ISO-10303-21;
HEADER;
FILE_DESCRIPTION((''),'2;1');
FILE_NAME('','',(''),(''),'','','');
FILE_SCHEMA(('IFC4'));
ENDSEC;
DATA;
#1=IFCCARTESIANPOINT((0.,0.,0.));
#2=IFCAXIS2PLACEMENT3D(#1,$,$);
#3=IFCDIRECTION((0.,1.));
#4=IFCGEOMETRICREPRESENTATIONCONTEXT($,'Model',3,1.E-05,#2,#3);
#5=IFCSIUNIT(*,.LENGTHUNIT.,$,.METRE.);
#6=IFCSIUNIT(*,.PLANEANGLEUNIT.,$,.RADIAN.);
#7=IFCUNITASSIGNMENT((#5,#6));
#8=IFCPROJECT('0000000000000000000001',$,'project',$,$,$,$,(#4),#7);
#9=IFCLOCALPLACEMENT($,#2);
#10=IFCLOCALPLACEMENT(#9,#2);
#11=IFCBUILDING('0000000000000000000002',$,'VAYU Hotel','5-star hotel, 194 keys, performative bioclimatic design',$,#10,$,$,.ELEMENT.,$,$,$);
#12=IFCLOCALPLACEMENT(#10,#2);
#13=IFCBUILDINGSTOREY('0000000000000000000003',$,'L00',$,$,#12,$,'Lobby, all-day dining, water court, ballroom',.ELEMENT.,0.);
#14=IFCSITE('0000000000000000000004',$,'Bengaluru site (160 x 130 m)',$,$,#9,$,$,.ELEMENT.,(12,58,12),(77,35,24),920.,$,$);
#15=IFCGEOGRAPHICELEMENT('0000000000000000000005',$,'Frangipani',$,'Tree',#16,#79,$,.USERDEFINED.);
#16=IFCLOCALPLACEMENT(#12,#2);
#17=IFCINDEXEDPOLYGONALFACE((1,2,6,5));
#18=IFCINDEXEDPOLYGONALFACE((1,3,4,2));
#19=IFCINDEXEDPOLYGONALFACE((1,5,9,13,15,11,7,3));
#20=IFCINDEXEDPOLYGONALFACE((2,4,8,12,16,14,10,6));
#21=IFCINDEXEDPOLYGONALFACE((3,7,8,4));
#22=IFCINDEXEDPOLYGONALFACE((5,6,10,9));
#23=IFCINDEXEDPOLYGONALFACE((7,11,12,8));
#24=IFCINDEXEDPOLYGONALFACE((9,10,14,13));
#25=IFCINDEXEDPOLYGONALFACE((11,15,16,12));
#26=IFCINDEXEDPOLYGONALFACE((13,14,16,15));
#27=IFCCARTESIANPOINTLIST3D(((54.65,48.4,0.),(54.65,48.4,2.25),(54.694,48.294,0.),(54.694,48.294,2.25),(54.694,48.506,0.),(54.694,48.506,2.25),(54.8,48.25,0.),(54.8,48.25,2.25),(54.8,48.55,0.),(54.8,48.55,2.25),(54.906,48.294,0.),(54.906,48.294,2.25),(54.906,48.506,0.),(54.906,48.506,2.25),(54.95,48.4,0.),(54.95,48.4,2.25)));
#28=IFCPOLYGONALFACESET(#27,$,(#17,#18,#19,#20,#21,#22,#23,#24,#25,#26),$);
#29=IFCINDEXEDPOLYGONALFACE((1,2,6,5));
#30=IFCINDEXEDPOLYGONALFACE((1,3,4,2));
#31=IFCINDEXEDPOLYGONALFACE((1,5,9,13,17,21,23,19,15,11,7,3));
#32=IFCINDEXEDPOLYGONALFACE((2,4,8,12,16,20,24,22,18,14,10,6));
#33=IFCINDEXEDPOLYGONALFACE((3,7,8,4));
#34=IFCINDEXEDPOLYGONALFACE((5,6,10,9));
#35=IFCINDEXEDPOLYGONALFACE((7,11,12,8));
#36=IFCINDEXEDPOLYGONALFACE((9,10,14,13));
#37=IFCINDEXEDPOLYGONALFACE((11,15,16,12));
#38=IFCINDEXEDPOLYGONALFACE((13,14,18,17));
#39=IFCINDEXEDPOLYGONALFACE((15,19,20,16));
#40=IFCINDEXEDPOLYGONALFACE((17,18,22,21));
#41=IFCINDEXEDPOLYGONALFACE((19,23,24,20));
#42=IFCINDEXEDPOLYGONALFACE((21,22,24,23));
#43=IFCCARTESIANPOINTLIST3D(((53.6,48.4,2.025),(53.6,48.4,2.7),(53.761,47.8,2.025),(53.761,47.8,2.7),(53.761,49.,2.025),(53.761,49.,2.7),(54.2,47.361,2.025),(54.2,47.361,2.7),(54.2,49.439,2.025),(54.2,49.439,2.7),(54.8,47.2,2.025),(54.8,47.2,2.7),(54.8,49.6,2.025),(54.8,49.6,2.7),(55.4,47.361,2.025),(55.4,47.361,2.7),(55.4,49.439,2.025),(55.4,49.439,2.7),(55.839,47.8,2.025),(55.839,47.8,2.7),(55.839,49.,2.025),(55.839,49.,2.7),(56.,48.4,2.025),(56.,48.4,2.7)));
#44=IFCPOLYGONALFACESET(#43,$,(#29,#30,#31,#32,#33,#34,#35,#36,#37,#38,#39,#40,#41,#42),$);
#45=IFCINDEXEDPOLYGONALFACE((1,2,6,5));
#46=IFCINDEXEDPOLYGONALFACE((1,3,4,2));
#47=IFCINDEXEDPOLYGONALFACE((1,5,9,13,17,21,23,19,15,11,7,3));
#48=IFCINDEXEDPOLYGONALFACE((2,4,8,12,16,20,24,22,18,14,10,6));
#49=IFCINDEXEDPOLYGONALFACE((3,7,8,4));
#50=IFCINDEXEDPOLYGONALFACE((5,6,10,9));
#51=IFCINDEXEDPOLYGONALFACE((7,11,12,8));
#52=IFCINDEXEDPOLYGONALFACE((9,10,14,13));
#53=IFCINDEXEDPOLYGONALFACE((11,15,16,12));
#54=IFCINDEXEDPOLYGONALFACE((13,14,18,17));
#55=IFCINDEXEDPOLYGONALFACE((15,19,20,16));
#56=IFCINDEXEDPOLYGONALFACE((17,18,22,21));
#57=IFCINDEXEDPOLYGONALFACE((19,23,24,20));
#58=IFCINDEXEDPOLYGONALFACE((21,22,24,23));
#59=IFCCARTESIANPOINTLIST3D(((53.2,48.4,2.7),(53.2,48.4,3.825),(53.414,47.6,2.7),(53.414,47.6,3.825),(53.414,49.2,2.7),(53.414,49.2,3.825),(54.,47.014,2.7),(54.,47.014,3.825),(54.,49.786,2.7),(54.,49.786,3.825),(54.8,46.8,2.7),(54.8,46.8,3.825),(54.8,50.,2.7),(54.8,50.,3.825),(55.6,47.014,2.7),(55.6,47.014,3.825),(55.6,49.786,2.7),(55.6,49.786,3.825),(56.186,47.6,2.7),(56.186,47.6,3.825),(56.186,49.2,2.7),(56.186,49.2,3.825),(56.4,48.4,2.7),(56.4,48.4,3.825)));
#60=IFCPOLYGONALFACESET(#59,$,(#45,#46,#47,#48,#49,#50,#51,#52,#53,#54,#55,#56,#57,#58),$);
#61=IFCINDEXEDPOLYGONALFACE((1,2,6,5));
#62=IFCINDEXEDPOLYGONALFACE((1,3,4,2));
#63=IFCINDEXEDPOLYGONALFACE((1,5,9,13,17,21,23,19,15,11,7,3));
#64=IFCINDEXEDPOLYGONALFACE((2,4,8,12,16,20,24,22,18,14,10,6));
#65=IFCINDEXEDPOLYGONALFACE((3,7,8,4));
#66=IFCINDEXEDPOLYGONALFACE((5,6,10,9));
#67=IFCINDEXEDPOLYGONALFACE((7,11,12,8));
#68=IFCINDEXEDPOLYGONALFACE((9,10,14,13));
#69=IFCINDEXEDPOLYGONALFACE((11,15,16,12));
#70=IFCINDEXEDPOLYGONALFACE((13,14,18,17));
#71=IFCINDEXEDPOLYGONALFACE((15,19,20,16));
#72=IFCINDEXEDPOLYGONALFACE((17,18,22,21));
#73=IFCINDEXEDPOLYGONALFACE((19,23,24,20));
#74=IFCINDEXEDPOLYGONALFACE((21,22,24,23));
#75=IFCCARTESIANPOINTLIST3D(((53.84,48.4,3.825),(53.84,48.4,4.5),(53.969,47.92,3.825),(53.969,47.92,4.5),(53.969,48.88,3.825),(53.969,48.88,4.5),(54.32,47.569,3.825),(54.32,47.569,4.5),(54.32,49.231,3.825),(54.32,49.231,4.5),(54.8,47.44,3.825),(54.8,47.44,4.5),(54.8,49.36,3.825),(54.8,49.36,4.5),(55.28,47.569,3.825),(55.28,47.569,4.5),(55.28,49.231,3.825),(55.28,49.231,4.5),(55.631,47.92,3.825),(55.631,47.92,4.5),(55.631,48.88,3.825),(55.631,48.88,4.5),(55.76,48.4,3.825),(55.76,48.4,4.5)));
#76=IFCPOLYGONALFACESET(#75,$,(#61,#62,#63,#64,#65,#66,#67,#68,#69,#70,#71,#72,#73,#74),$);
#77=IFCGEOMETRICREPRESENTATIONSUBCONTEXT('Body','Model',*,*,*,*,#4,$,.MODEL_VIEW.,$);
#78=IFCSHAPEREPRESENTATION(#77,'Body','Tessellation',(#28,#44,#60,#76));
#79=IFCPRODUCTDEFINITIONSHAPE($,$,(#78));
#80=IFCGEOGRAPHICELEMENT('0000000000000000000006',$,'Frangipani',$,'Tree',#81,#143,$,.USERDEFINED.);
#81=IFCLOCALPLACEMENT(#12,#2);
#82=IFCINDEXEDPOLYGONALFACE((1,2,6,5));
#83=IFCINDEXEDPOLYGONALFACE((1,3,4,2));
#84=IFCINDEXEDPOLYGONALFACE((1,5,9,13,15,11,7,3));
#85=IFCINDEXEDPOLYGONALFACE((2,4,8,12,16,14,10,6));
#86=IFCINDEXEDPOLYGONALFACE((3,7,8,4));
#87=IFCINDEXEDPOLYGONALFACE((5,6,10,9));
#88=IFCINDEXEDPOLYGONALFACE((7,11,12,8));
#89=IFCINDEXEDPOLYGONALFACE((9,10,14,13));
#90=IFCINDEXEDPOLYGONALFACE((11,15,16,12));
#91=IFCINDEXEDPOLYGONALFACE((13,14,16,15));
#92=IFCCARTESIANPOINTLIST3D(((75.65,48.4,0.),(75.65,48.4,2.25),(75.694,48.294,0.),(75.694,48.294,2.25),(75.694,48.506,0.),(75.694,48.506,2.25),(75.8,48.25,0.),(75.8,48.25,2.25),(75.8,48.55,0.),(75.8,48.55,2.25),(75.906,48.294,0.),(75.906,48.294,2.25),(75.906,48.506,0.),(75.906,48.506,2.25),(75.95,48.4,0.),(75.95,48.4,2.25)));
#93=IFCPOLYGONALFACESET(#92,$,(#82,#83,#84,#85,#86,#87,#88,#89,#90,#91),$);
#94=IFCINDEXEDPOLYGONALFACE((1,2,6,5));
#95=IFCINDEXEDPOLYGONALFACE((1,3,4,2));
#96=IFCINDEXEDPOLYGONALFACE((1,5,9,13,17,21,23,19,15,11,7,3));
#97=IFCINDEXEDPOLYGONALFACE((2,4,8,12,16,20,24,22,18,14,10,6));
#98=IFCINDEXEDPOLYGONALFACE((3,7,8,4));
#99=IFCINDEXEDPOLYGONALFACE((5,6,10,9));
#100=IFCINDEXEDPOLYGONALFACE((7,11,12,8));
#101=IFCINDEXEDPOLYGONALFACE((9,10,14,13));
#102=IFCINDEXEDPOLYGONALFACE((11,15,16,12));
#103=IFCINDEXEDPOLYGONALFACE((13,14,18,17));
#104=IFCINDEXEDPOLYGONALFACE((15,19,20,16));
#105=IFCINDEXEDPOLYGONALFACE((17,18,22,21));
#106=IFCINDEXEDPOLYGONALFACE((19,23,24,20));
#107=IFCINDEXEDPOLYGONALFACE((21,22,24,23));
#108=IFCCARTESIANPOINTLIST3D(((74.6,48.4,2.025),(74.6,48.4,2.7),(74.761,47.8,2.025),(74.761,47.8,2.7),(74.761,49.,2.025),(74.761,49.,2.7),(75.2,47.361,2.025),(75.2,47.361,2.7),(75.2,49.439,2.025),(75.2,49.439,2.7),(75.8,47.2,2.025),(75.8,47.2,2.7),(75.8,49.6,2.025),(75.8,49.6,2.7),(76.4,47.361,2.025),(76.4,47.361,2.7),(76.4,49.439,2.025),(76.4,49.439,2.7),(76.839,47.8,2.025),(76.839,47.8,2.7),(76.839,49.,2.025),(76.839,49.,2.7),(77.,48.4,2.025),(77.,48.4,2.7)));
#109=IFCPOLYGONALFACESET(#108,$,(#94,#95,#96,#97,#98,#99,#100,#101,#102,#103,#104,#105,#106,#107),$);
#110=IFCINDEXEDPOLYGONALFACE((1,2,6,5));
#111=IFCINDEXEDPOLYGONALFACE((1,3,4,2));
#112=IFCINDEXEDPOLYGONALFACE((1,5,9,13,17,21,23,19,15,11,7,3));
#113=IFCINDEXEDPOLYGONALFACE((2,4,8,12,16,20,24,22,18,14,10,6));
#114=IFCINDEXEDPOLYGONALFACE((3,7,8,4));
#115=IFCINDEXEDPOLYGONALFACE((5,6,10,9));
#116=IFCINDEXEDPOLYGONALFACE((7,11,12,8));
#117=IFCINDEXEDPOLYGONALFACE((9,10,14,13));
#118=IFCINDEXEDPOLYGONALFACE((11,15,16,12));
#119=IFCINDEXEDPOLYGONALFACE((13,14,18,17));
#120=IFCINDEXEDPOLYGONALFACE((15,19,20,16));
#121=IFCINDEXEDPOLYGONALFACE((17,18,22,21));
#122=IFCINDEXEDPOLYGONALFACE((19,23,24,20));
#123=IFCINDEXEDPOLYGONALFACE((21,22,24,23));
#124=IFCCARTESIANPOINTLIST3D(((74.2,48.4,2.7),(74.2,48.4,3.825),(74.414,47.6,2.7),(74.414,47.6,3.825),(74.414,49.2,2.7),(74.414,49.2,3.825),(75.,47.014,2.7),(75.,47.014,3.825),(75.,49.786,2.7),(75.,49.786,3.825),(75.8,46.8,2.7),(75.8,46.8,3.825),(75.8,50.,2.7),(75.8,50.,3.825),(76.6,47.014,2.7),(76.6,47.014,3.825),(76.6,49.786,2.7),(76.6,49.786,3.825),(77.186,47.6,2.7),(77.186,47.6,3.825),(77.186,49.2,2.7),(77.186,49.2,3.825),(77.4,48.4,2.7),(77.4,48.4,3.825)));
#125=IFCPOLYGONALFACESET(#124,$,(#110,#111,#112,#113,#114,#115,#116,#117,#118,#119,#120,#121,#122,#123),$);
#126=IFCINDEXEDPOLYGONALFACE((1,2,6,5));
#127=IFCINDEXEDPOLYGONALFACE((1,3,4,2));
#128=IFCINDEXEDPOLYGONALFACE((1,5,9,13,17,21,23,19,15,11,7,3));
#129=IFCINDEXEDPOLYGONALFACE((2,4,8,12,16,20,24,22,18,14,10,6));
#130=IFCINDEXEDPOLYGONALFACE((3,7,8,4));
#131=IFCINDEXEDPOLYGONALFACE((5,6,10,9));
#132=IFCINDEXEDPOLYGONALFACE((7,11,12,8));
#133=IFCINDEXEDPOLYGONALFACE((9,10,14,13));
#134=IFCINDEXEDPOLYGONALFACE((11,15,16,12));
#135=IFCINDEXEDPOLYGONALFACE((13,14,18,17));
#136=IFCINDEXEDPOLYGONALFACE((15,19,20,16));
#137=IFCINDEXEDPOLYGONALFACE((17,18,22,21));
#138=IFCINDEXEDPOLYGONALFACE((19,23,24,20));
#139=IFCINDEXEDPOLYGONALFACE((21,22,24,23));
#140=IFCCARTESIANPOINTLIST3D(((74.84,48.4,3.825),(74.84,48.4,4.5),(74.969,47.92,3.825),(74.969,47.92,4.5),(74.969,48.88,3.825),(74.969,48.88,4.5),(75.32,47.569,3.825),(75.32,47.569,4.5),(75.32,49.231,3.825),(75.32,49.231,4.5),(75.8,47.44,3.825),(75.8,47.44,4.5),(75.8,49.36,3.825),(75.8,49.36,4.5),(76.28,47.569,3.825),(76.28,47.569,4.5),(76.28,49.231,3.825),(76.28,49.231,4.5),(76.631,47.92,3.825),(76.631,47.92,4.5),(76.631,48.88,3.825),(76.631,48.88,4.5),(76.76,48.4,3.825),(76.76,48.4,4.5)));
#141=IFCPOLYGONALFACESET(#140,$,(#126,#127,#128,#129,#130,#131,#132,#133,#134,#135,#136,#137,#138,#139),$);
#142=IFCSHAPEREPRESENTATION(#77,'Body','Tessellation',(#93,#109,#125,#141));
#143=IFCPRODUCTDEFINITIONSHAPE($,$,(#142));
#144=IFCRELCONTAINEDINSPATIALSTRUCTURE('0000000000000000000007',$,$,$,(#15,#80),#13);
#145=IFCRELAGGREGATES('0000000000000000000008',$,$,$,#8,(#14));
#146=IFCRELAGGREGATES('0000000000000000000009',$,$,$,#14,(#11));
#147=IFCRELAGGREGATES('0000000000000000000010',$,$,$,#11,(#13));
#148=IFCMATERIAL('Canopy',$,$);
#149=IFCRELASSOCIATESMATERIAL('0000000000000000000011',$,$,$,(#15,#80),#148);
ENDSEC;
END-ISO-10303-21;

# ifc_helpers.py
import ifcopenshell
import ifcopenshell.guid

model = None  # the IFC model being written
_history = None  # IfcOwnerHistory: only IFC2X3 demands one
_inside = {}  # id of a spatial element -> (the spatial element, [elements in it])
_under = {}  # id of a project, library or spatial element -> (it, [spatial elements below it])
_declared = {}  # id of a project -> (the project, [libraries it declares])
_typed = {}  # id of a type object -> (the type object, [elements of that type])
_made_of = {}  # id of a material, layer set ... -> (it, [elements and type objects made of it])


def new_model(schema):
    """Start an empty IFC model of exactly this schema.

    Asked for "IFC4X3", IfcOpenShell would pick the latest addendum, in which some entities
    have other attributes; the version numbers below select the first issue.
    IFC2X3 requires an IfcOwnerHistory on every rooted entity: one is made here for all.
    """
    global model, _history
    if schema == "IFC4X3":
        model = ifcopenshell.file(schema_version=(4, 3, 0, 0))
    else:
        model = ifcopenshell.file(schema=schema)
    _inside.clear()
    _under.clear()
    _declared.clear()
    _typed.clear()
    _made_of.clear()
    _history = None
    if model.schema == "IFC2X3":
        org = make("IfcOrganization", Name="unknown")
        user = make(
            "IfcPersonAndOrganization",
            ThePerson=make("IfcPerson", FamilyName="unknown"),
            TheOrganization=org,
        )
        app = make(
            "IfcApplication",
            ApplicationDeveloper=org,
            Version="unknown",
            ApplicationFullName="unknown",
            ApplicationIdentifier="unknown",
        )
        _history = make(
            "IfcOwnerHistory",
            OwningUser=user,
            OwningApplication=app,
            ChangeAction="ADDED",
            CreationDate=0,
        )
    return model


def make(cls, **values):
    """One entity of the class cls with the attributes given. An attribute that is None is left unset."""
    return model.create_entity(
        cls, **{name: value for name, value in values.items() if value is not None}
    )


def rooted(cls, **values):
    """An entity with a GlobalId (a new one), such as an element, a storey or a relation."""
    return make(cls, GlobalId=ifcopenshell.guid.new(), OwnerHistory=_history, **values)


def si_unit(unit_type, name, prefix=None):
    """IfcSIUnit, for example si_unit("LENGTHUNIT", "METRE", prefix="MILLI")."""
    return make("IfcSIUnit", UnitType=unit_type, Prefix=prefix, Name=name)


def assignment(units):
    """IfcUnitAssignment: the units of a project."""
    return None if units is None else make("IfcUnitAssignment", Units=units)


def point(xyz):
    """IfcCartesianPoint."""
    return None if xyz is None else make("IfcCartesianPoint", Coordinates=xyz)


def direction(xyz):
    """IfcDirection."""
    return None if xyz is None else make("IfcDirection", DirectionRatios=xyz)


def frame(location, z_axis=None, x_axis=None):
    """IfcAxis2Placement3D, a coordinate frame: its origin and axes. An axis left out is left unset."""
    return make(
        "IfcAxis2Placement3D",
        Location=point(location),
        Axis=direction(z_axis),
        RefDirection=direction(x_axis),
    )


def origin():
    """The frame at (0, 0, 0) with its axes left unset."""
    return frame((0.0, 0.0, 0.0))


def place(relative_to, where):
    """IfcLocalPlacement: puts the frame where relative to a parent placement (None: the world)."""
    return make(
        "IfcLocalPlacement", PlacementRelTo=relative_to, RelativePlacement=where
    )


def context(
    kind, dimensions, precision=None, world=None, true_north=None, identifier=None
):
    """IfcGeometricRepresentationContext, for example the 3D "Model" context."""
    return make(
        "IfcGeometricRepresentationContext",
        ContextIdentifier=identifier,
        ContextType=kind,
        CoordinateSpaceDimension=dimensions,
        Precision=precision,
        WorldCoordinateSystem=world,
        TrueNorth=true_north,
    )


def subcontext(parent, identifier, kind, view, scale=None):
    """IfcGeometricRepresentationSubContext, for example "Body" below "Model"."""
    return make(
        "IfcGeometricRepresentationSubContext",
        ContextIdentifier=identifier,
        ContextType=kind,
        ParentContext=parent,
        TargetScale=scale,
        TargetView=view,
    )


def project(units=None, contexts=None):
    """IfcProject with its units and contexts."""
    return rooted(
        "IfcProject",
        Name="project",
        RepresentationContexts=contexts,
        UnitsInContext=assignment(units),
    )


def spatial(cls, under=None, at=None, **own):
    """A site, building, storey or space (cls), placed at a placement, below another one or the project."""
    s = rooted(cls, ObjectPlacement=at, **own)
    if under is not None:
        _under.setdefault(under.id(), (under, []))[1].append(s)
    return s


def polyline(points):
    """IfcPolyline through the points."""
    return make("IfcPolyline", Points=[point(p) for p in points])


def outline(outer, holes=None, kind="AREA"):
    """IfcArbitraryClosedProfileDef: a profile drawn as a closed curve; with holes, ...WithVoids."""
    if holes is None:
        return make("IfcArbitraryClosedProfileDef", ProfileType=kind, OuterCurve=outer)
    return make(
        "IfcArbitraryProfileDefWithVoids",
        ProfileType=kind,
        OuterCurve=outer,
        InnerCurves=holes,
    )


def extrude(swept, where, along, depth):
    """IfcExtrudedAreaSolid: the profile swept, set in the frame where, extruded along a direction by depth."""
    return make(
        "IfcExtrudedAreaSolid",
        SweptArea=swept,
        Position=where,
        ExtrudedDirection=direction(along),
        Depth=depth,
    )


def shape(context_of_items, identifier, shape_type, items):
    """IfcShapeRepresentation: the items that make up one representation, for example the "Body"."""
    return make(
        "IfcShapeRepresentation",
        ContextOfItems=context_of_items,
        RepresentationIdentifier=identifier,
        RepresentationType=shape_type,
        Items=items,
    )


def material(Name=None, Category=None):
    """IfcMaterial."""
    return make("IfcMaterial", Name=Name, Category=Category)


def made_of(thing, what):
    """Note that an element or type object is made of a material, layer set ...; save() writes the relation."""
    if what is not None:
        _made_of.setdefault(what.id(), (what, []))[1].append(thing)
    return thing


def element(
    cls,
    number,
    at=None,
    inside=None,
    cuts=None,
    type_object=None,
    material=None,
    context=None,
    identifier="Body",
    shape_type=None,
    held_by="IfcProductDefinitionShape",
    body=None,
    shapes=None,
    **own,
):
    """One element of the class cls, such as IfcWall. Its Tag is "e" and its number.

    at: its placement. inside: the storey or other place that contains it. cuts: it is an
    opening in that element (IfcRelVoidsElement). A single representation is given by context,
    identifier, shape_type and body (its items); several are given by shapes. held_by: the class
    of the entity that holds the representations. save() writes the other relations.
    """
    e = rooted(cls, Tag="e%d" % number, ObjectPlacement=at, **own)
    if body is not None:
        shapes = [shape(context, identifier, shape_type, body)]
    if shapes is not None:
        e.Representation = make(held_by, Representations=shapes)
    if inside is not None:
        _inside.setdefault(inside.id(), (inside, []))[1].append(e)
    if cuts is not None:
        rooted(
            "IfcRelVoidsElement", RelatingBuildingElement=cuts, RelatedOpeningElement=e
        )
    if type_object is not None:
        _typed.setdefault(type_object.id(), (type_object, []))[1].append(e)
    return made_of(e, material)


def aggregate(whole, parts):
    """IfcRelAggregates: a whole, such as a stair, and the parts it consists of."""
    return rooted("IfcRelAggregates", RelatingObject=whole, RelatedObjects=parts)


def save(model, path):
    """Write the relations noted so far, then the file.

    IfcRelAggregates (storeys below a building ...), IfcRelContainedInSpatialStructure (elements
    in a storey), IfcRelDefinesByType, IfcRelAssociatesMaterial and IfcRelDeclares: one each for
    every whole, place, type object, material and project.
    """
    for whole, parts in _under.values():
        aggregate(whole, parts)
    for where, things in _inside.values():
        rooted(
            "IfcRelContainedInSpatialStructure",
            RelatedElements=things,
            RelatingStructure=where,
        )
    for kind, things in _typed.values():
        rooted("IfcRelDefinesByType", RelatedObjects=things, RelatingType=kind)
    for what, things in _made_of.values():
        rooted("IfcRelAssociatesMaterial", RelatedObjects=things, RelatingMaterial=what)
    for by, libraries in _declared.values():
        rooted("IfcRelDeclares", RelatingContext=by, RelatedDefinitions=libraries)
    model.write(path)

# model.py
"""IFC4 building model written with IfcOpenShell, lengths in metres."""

from ifc_helpers import new_model, si_unit, direction, frame, origin, place, context, subcontext, project, spatial, polyline, outline, extrude, material, element, save


model = new_model("IFC4")

# Units and contexts
model_context = context("Model", 3, precision=1e-05, world=origin(), true_north=direction((0.0, 1.0)))
body_context = subcontext(model_context, "Body", "Model", "MODEL_VIEW")
ifc_project = project(units=[si_unit("LENGTHUNIT", "METRE"), si_unit("PLANEANGLEUNIT", "RADIAN")], contexts=[model_context])

# Site, building, storey
site_placement = place(None, origin())
site = spatial("IfcSite", under=ifc_project, at=site_placement, Name="Bengaluru site (160 x 130 m)", CompositionType="ELEMENT", RefLatitude=(12, 58, 12), RefLongitude=(77, 35, 24), RefElevation=920.0)
building_placement = place(site_placement, origin())
building = spatial("IfcBuilding", under=site, at=building_placement, Name="VAYU Hotel", Description="5-star hotel, 194 keys, performative bioclimatic design", CompositionType="ELEMENT")
storey_placement = place(building_placement, origin())
storey = spatial("IfcBuildingStorey", under=building, at=storey_placement, Name="L00", LongName="Lobby, all-day dining, water court, ballroom", CompositionType="ELEMENT", Elevation=0.0)

# Geographic elements
ifc_material_1 = material(Name="Canopy")
geographic_element_1_placement = place(storey_placement, origin())
element("IfcGeographicElement", 1, at=geographic_element_1_placement, inside=storey, material=ifc_material_1, Name="Frangipani", ObjectType="Tree", PredefinedType="USERDEFINED", context=body_context, shape_type="SweptSolid", body=[
    extrude(outline(polyline([(54.95, 48.4), (54.906, 48.506), (54.8, 48.55), (54.694, 48.506), (54.65, 48.4), (54.694, 48.294), (54.8, 48.25), (54.906, 48.294), (54.95, 48.4)])), origin(), (0.0, 0.0, 1.0), 2.25),
    extrude(outline(polyline([(56.0, 48.4), (55.839, 49.0), (55.4, 49.439), (54.8, 49.6), (54.2, 49.439), (53.761, 49.0), (53.6, 48.4), (53.761, 47.8), (54.2, 47.361), (54.8, 47.2), (55.4, 47.361), (55.839, 47.8), (56.0, 48.4)])), frame((0.0, 0.0, 2.025)), (0.0, 0.0, 1.0), 0.675),
    extrude(outline(polyline([(56.4, 48.4), (56.186, 49.2), (55.6, 49.786), (54.8, 50.0), (54.0, 49.786), (53.414, 49.2), (53.2, 48.4), (53.414, 47.6), (54.0, 47.014), (54.8, 46.8), (55.6, 47.014), (56.186, 47.6), (56.4, 48.4)])), frame((0.0, 0.0, 2.7)), (0.0, 0.0, 1.0), 1.125),
    extrude(outline(polyline([(55.76, 48.4), (55.631, 48.88), (55.28, 49.231), (54.8, 49.36), (54.32, 49.231), (53.969, 48.88), (53.84, 48.4), (53.969, 47.92), (54.32, 47.569), (54.8, 47.44), (55.28, 47.569), (55.631, 47.92), (55.76, 48.4)])), frame((0.0, 0.0, 3.825)), (0.0, 0.0, 1.0), 0.675),
])
geographic_element_2_placement = place(storey_placement, origin())
element("IfcGeographicElement", 2, at=geographic_element_2_placement, inside=storey, material=ifc_material_1, Name="Frangipani", ObjectType="Tree", PredefinedType="USERDEFINED", context=body_context, shape_type="SweptSolid", body=[
    extrude(outline(polyline([(75.95, 48.4), (75.906, 48.506), (75.8, 48.55), (75.694, 48.506), (75.65, 48.4), (75.694, 48.294), (75.8, 48.25), (75.906, 48.294), (75.95, 48.4)])), origin(), (0.0, 0.0, 1.0), 2.25),
    extrude(outline(polyline([(77.0, 48.4), (76.839, 49.0), (76.4, 49.439), (75.8, 49.6), (75.2, 49.439), (74.761, 49.0), (74.6, 48.4), (74.761, 47.8), (75.2, 47.361), (75.8, 47.2), (76.4, 47.361), (76.839, 47.8), (77.0, 48.4)])), frame((0.0, 0.0, 2.025)), (0.0, 0.0, 1.0), 0.675),
    extrude(outline(polyline([(77.4, 48.4), (77.186, 49.2), (76.6, 49.786), (75.8, 50.0), (75.0, 49.786), (74.414, 49.2), (74.2, 48.4), (74.414, 47.6), (75.0, 47.014), (75.8, 46.8), (76.6, 47.014), (77.186, 47.6), (77.4, 48.4)])), frame((0.0, 0.0, 2.7)), (0.0, 0.0, 1.0), 1.125),
    extrude(outline(polyline([(76.76, 48.4), (76.631, 48.88), (76.28, 49.231), (75.8, 49.36), (75.32, 49.231), (74.969, 48.88), (74.84, 48.4), (74.969, 47.92), (75.32, 47.569), (75.8, 47.44), (76.28, 47.569), (76.631, 47.92), (76.76, 48.4)])), frame((0.0, 0.0, 3.825)), (0.0, 0.0, 1.0), 0.675),
])

save(model, "model.ifc")
